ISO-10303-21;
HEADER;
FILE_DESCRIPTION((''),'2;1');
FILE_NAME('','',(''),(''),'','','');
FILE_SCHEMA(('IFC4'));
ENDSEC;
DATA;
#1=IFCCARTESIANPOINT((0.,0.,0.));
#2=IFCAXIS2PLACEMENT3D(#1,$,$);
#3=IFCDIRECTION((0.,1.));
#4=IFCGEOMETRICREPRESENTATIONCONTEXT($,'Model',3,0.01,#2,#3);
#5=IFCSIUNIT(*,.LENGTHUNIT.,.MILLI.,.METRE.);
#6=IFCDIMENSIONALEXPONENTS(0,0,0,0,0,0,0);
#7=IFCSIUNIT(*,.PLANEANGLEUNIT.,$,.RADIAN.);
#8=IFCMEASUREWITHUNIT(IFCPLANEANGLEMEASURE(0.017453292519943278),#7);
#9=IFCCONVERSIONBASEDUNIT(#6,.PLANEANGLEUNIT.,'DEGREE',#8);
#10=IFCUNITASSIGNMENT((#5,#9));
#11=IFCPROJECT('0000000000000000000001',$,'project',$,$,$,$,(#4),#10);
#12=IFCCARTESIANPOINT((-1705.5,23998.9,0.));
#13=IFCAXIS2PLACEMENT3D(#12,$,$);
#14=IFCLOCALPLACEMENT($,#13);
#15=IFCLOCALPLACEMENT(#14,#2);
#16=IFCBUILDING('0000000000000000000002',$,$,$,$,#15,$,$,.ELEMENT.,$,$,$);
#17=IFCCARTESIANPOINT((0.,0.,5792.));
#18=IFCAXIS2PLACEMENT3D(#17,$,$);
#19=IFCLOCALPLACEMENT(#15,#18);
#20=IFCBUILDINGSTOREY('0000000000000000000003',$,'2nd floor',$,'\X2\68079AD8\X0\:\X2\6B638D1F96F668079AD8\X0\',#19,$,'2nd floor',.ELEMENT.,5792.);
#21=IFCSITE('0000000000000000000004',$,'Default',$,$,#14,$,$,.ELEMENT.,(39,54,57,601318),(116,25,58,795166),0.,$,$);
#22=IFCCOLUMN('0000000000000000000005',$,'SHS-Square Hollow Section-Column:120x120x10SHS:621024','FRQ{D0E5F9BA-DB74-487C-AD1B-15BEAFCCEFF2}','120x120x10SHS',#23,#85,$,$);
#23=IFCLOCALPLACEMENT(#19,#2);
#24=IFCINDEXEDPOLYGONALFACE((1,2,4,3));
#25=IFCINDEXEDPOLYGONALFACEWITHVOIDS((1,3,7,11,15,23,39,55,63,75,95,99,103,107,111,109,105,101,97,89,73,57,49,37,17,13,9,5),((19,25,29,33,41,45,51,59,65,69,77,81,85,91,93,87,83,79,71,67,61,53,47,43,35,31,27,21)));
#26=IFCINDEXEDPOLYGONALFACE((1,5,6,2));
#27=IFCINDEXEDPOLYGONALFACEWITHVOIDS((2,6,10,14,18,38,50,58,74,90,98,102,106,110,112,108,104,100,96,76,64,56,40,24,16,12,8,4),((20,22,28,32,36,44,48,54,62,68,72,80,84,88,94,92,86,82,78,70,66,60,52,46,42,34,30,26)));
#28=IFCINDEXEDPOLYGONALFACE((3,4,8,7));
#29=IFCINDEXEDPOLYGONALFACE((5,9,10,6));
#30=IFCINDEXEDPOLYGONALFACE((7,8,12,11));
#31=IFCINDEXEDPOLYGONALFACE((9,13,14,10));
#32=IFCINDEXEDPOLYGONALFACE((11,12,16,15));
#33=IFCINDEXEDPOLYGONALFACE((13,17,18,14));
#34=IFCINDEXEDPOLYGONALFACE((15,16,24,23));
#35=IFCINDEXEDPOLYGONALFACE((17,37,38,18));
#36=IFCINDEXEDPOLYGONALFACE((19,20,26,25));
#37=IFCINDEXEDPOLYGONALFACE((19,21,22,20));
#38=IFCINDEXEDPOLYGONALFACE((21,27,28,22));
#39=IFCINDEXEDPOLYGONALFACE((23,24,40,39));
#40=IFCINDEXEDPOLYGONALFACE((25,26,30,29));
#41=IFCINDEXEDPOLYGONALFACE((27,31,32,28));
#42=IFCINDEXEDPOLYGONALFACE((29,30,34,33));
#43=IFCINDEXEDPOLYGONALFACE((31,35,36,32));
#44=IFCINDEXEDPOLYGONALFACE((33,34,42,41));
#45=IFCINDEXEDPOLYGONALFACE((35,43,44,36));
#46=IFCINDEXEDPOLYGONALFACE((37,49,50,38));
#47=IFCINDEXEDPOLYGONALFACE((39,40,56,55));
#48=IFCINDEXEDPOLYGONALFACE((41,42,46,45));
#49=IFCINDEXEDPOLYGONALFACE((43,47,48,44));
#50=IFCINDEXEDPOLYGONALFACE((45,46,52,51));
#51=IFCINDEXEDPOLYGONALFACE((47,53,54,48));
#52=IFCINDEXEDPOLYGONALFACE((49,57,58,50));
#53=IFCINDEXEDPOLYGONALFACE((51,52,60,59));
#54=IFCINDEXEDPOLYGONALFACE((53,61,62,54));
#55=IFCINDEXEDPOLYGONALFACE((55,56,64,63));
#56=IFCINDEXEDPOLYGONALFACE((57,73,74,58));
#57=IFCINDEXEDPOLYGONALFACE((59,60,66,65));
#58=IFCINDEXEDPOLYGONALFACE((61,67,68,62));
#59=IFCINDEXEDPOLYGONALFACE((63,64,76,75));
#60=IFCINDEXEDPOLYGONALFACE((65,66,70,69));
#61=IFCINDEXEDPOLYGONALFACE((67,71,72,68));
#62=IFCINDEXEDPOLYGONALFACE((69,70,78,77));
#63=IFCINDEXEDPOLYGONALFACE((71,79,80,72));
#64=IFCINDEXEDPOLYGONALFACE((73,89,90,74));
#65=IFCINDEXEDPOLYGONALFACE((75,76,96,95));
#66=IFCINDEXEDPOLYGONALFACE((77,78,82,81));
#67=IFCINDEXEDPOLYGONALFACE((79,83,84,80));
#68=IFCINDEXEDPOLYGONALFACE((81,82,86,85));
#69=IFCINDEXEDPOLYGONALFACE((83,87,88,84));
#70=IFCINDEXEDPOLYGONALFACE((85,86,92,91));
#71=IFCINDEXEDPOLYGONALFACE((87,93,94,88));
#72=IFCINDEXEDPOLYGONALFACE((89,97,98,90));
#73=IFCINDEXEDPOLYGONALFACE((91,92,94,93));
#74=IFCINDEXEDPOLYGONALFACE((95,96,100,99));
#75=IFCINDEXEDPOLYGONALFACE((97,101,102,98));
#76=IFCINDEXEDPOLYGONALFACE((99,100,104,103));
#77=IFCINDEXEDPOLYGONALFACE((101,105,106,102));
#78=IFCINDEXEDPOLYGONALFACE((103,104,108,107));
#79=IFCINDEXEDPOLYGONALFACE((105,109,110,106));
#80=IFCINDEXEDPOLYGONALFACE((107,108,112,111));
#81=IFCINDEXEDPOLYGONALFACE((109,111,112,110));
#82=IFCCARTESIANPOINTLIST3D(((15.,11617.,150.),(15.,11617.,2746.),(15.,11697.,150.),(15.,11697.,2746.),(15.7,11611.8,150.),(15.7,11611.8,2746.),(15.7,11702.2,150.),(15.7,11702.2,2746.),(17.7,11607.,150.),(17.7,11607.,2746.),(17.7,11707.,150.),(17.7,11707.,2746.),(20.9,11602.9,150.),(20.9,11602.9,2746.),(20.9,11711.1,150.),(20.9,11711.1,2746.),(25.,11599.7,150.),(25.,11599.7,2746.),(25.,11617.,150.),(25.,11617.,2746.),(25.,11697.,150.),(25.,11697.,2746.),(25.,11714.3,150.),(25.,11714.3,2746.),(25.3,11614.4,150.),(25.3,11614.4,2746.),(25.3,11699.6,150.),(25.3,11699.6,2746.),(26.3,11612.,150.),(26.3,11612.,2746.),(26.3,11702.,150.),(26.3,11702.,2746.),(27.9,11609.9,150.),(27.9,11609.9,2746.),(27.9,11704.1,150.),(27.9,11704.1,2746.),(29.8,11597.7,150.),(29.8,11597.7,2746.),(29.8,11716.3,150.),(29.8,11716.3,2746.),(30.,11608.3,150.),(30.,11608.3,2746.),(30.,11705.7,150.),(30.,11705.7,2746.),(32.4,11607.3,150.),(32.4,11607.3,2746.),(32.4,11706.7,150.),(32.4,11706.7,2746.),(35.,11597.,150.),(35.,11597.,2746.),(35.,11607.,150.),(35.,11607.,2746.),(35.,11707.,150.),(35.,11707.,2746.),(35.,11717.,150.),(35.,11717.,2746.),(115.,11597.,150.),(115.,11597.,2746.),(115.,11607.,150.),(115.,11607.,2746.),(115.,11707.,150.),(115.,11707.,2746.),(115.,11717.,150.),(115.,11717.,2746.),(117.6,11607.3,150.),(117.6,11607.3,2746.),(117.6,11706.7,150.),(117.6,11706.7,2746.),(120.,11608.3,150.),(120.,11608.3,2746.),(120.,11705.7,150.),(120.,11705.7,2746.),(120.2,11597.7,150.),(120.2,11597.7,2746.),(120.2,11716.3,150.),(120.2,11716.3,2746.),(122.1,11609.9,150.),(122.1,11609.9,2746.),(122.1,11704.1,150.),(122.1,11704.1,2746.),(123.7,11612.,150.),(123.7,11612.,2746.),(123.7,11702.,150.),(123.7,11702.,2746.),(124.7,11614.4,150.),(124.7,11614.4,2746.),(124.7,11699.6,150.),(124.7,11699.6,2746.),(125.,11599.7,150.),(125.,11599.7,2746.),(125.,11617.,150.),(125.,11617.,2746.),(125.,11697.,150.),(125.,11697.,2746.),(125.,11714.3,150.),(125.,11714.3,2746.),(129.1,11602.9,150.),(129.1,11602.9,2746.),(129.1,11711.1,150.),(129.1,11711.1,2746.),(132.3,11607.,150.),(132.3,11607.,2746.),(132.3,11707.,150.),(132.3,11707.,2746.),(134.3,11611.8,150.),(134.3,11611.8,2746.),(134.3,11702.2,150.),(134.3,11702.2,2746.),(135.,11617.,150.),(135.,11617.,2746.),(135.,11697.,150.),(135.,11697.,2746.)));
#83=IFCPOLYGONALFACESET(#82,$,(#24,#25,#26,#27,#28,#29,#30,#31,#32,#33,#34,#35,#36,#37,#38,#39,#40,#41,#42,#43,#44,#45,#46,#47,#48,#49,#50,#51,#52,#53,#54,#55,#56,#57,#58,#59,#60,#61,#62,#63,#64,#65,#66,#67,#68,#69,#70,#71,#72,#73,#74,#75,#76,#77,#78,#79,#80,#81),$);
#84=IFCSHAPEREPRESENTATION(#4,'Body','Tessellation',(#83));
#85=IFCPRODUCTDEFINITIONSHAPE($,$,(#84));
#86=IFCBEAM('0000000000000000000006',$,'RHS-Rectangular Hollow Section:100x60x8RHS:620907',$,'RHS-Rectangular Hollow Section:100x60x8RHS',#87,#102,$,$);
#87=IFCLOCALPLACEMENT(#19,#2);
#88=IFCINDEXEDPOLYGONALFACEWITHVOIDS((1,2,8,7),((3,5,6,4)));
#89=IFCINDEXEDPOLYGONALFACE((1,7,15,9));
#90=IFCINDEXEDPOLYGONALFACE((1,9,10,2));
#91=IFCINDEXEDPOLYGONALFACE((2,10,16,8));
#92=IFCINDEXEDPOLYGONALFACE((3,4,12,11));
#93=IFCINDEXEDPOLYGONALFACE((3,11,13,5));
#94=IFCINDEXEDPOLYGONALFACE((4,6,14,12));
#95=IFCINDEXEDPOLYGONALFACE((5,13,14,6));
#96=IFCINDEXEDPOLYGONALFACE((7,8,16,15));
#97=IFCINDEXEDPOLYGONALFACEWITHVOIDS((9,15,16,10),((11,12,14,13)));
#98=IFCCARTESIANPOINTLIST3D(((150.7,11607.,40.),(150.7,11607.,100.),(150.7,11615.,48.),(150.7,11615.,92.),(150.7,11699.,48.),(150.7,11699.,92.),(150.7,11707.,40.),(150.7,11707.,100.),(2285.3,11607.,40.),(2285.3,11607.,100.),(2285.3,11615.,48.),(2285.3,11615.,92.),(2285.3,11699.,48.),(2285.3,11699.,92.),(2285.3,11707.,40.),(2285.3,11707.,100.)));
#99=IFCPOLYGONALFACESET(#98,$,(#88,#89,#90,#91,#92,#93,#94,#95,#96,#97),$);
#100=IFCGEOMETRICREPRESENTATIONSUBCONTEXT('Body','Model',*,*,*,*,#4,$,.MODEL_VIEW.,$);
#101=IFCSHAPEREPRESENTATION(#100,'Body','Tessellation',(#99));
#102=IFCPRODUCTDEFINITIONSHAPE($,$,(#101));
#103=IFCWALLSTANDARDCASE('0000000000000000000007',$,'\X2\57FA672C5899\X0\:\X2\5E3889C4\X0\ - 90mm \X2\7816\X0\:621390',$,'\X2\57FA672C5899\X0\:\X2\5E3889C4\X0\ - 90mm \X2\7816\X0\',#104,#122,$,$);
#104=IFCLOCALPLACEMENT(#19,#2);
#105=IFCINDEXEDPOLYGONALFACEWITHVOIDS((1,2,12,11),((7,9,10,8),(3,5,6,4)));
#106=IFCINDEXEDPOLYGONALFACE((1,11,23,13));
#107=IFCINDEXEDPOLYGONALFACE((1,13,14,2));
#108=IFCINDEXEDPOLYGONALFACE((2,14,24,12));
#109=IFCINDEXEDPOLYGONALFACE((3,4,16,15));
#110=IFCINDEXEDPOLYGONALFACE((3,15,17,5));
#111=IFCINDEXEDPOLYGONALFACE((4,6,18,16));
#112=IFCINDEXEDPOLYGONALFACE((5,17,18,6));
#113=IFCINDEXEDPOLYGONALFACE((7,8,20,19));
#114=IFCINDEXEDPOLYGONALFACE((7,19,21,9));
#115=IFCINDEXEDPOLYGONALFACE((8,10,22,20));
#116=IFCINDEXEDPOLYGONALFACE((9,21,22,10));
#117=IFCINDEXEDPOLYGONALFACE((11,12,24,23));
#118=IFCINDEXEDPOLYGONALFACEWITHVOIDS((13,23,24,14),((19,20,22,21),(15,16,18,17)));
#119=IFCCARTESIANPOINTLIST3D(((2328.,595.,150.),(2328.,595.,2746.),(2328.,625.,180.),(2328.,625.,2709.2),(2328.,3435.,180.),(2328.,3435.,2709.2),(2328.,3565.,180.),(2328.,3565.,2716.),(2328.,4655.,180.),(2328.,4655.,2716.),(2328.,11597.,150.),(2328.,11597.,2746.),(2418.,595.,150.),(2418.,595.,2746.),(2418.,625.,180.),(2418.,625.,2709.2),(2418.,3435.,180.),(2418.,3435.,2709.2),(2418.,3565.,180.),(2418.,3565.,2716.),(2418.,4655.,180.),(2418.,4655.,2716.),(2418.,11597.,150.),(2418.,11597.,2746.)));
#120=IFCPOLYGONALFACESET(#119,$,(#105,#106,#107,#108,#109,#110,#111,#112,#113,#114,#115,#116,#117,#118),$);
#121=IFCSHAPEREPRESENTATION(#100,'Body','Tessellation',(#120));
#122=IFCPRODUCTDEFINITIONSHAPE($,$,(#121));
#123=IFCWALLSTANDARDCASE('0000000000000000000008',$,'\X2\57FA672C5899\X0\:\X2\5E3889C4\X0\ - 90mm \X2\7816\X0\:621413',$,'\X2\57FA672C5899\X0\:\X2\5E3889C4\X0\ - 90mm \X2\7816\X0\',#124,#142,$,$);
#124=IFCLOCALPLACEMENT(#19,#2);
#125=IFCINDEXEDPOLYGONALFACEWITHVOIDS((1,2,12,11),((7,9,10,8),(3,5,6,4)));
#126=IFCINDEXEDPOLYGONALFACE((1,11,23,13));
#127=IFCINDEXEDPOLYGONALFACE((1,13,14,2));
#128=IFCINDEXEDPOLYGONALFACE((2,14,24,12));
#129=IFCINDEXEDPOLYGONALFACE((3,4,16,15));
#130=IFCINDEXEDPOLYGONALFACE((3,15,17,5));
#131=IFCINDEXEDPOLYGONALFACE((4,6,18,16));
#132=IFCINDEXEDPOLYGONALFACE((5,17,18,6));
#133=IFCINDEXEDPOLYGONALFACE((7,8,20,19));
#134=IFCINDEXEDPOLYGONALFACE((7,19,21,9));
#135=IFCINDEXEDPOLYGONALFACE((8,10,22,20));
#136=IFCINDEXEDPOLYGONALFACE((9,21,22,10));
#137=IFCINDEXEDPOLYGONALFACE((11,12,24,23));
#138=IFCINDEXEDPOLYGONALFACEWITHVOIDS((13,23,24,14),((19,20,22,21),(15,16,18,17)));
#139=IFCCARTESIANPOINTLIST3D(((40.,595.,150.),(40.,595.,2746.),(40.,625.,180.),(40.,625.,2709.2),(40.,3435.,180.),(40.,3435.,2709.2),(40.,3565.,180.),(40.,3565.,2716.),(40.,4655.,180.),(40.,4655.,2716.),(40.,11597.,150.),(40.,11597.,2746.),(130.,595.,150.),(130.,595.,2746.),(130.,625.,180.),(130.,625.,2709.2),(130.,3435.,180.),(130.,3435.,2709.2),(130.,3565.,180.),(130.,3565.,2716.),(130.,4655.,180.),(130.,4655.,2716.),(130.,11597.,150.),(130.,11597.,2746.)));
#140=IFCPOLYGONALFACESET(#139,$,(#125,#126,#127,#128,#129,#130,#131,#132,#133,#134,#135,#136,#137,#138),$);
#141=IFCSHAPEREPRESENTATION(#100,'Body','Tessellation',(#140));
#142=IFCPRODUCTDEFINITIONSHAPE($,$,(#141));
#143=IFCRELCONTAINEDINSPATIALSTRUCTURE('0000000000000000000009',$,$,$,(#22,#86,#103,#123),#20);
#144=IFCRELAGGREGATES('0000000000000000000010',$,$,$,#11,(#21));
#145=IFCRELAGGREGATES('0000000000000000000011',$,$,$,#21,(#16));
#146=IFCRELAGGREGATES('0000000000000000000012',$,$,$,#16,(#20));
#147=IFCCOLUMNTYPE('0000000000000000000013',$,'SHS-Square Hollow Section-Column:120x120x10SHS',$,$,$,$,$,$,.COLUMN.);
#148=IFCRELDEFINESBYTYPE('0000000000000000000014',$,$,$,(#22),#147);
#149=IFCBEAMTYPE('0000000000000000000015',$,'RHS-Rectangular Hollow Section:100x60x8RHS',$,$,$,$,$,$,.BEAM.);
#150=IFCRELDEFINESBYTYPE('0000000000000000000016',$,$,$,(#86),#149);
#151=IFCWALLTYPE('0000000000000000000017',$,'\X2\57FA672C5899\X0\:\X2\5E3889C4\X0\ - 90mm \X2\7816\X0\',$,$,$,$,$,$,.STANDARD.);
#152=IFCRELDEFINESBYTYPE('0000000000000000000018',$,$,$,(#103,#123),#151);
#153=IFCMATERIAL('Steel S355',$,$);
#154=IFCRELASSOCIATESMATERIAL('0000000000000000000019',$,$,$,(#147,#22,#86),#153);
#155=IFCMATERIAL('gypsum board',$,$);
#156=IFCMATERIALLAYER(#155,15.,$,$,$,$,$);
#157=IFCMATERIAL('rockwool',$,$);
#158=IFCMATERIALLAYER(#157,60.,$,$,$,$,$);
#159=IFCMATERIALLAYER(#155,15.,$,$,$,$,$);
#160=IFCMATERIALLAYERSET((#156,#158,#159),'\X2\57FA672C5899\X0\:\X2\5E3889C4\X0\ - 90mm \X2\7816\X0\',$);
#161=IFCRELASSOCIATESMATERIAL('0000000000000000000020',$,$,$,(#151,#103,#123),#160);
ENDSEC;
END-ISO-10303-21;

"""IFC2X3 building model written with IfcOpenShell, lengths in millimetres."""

from ifc_helpers import new_model, entity, si_unit, converted_unit, direction, frame, frame_2d, origin, origin_2d, place, context, subcontext, project, spatial, rectangle, hollow_rectangle, extrude, boolean, clip, halfspace, material, layer, layer_set, layer_usage, type_object, element, save


model = new_model("IFC2X3")

# Units and contexts
model_context = context("Model", 3, precision=0.01, world=origin(), true_north=direction((0.0, 1.0)))
body_context = subcontext(model_context, "Body", "Model", "MODEL_VIEW")
ifc_project = project(units=[si_unit("LENGTHUNIT", "METRE", prefix="MILLI"), converted_unit("PLANEANGLEUNIT", "DEGREE", entity("IfcPlaneAngleMeasure", 0.017453292519943278), si_unit("PLANEANGLEUNIT", "RADIAN"), dimensions=[0, 0, 0, 0, 0, 0, 0])], contexts=[model_context])

# Site, building, storey
site_placement = place(None, frame((-1705.5, 23998.9, 0.0)))
site = spatial("IfcSite", under=ifc_project, at=site_placement, Name="Default", CompositionType="ELEMENT", RefLatitude=(39, 54, 57, 601318), RefLongitude=(116, 25, 58, 795166), RefElevation=0.0)
building_placement = place(site_placement, origin())
building = spatial("IfcBuilding", under=site, at=building_placement, CompositionType="ELEMENT")
storey_placement = place(building_placement, frame((0.0, 0.0, 5792.0)))
storey = spatial("IfcBuildingStorey", under=building, at=storey_placement, Name="2nd floor", ObjectType="标高:正负零标高", LongName="2nd floor", CompositionType="ELEMENT", Elevation=5792.0)

# Shared definitions
ifc_material_1 = material(Name="Steel S355")

# Column
column_type_1 = type_object("IfcColumnType", Name="SHS-Square Hollow Section-Column:120x120x10SHS", PredefinedType="COLUMN", material=ifc_material_1)
column_1_placement = place(storey_placement, frame((75.0, 11657.0, 2830.9), z_axis=(0.0, 0.0, 1.0), x_axis=(0.0, -1.0, 0.0)))
element("IfcColumn", 1, at=column_1_placement, inside=storey, type_object=column_type_1, material=ifc_material_1, Name="SHS-Square Hollow Section-Column:120x120x10SHS:621024", Description="FRQ{D0E5F9BA-DB74-487C-AD1B-15BEAFCCEFF2}", ObjectType="120x120x10SHS", context=model_context, shape_type="Clipping", body=[
    clip(clip(extrude(hollow_rectangle(XDim=120.0, YDim=120.0, WallThickness=10.0, InnerFilletRadius=10.0, OuterFilletRadius=20.0, at=origin_2d()), origin(), (0.0, 0.0, -1.0), 2765.7), halfspace(frame((11657.0, -75.0, -84.9), z_axis=(0.0, 0.0, -1.0), x_axis=(0.0, -1.0, 0.0)), True)), halfspace(frame((11657.0, -75.0, -2680.9), z_axis=(0.0, 0.0, 1.0), x_axis=(0.0, 1.0, 0.0)), True)),
])

# Beam
beam_type_1 = type_object("IfcBeamType", Name="RHS-Rectangular Hollow Section:100x60x8RHS", PredefinedType="BEAM")
beam_1_placement = place(storey_placement, frame((150.7, 11707.0, 70.0)))
element("IfcBeam", 2, at=beam_1_placement, inside=storey, type_object=beam_type_1, material=ifc_material_1, Name="RHS-Rectangular Hollow Section:100x60x8RHS:620907", ObjectType="RHS-Rectangular Hollow Section:100x60x8RHS", context=body_context, shape_type="SweptSolid", body=[
    boolean("DIFFERENCE", extrude(rectangle(XDim=60.0, YDim=100.0, at=frame_2d((0.0, 0.0), x_axis=(1.0, 0.0))), frame((0.0, -50.0, 0.0), z_axis=(1.0, 0.0, 0.0), x_axis=(0.0, 0.0, -1.0)), (0.0, 0.0, 1.0), 2134.6), extrude(rectangle(XDim=44.0, YDim=84.0, at=frame_2d((0.0, 0.0), x_axis=(0.0, 1.0))), frame((2134.6, -50.0, 0.0), z_axis=(-1.0, 0.0, 0.0), x_axis=(0.0, 1.0, 0.0)), (0.0, 0.0, 1.0), 2134.6)),
])

# Shared definitions
ifc_material_2 = material(Name="gypsum board")
ifc_layer_1 = layer(ifc_material_2, 15.0)
ifc_material_3 = material(Name="rockwool")
ifc_layer_2 = layer(ifc_material_3, 60.0)
ifc_layer_3 = layer(ifc_material_2, 15.0)
ifc_layer_set = layer_set([ifc_layer_1, ifc_layer_2, ifc_layer_3], Name="基本墙:常规 - 90mm 砖")
wall_type = type_object("IfcWallType", Name="基本墙:常规 - 90mm 砖", PredefinedType="STANDARD", material=ifc_layer_set)

# Walls, openings
ifc_layer_usage_1 = layer_usage(ifc_layer_set, "AXIS2", "NEGATIVE", 45.0)
wall_1_placement = place(storey_placement, frame((2373.0, 11597.0, 150.0), z_axis=(0.0, 0.0, 1.0), x_axis=(0.0, -1.0, 0.0)))
wall_1 = element("IfcWallStandardCase", 3, at=wall_1_placement, inside=storey, type_object=wall_type, material=ifc_layer_usage_1, Name="基本墙:常规 - 90mm 砖:621390", ObjectType="基本墙:常规 - 90mm 砖", context=body_context, shape_type="SweptSolid", body=[
    extrude(rectangle(XDim=11002.0, YDim=90.0, at=frame_2d((5501.0, 0.0), x_axis=(-1.0, 0.0))), origin(), (0.0, 0.0, 1.0), 2596.0),
])
opening_1_placement = place(wall_1_placement, origin())
element("IfcOpeningElement", 4, at=opening_1_placement, cuts=wall_1, ObjectType="Opening", context=body_context, shape_type="SweptSolid", body=[
    extrude(rectangle(XDim=2536.0, YDim=1090.0, at=frame_2d((0.0, 0.0), x_axis=(0.0, 1.0))), frame((7487.0, 45.0, 1298.0), z_axis=(0.0, -1.0, 0.0), x_axis=(-1.0, 0.0, 0.0)), (0.0, 0.0, 1.0), 90.0),
])
opening_2_placement = place(wall_1_placement, origin())
element("IfcOpeningElement", 5, at=opening_2_placement, cuts=wall_1, ObjectType="Opening", context=body_context, shape_type="SweptSolid", body=[
    extrude(rectangle(XDim=2529.2, YDim=2810.0, at=frame_2d((0.0, 0.0), x_axis=(0.0, 1.0))), frame((9567.0, 45.0, 1294.6), z_axis=(0.0, -1.0, 0.0), x_axis=(-1.0, 0.0, 0.0)), (0.0, 0.0, 1.0), 90.0),
])
ifc_layer_usage_2 = layer_usage(ifc_layer_set, "AXIS2", "NEGATIVE", 45.0)
wall_2_placement = place(storey_placement, frame((85.0, 11597.0, 150.0), z_axis=(0.0, 0.0, 1.0), x_axis=(0.0, -1.0, 0.0)))
wall_2 = element("IfcWallStandardCase", 6, at=wall_2_placement, inside=storey, type_object=wall_type, material=ifc_layer_usage_2, Name="基本墙:常规 - 90mm 砖:621413", ObjectType="基本墙:常规 - 90mm 砖", context=body_context, shape_type="SweptSolid", body=[
    extrude(rectangle(XDim=11002.0, YDim=90.0, at=frame_2d((5501.0, 0.0), x_axis=(-1.0, 0.0))), origin(), (0.0, 0.0, 1.0), 2596.0),
])
opening_3_placement = place(wall_2_placement, origin())
element("IfcOpeningElement", 7, at=opening_3_placement, cuts=wall_2, ObjectType="Opening", context=body_context, shape_type="SweptSolid", body=[
    extrude(rectangle(XDim=2536.0, YDim=1090.0, at=frame_2d((0.0, 0.0), x_axis=(0.0, 1.0))), frame((7487.0, 45.0, 1298.0), z_axis=(0.0, -1.0, 0.0), x_axis=(-1.0, 0.0, 0.0)), (0.0, 0.0, 1.0), 90.0),
])
opening_4_placement = place(wall_2_placement, origin())
element("IfcOpeningElement", 8, at=opening_4_placement, cuts=wall_2, ObjectType="Opening", context=body_context, shape_type="SweptSolid", body=[
    extrude(rectangle(XDim=2529.2, YDim=2810.0, at=frame_2d((0.0, 0.0), x_axis=(0.0, 1.0))), frame((9567.0, 45.0, 1294.6), z_axis=(0.0, -1.0, 0.0), x_axis=(-1.0, 0.0, 0.0)), (0.0, 0.0, 1.0), 90.0),
])

save(model, "model.ifc")
